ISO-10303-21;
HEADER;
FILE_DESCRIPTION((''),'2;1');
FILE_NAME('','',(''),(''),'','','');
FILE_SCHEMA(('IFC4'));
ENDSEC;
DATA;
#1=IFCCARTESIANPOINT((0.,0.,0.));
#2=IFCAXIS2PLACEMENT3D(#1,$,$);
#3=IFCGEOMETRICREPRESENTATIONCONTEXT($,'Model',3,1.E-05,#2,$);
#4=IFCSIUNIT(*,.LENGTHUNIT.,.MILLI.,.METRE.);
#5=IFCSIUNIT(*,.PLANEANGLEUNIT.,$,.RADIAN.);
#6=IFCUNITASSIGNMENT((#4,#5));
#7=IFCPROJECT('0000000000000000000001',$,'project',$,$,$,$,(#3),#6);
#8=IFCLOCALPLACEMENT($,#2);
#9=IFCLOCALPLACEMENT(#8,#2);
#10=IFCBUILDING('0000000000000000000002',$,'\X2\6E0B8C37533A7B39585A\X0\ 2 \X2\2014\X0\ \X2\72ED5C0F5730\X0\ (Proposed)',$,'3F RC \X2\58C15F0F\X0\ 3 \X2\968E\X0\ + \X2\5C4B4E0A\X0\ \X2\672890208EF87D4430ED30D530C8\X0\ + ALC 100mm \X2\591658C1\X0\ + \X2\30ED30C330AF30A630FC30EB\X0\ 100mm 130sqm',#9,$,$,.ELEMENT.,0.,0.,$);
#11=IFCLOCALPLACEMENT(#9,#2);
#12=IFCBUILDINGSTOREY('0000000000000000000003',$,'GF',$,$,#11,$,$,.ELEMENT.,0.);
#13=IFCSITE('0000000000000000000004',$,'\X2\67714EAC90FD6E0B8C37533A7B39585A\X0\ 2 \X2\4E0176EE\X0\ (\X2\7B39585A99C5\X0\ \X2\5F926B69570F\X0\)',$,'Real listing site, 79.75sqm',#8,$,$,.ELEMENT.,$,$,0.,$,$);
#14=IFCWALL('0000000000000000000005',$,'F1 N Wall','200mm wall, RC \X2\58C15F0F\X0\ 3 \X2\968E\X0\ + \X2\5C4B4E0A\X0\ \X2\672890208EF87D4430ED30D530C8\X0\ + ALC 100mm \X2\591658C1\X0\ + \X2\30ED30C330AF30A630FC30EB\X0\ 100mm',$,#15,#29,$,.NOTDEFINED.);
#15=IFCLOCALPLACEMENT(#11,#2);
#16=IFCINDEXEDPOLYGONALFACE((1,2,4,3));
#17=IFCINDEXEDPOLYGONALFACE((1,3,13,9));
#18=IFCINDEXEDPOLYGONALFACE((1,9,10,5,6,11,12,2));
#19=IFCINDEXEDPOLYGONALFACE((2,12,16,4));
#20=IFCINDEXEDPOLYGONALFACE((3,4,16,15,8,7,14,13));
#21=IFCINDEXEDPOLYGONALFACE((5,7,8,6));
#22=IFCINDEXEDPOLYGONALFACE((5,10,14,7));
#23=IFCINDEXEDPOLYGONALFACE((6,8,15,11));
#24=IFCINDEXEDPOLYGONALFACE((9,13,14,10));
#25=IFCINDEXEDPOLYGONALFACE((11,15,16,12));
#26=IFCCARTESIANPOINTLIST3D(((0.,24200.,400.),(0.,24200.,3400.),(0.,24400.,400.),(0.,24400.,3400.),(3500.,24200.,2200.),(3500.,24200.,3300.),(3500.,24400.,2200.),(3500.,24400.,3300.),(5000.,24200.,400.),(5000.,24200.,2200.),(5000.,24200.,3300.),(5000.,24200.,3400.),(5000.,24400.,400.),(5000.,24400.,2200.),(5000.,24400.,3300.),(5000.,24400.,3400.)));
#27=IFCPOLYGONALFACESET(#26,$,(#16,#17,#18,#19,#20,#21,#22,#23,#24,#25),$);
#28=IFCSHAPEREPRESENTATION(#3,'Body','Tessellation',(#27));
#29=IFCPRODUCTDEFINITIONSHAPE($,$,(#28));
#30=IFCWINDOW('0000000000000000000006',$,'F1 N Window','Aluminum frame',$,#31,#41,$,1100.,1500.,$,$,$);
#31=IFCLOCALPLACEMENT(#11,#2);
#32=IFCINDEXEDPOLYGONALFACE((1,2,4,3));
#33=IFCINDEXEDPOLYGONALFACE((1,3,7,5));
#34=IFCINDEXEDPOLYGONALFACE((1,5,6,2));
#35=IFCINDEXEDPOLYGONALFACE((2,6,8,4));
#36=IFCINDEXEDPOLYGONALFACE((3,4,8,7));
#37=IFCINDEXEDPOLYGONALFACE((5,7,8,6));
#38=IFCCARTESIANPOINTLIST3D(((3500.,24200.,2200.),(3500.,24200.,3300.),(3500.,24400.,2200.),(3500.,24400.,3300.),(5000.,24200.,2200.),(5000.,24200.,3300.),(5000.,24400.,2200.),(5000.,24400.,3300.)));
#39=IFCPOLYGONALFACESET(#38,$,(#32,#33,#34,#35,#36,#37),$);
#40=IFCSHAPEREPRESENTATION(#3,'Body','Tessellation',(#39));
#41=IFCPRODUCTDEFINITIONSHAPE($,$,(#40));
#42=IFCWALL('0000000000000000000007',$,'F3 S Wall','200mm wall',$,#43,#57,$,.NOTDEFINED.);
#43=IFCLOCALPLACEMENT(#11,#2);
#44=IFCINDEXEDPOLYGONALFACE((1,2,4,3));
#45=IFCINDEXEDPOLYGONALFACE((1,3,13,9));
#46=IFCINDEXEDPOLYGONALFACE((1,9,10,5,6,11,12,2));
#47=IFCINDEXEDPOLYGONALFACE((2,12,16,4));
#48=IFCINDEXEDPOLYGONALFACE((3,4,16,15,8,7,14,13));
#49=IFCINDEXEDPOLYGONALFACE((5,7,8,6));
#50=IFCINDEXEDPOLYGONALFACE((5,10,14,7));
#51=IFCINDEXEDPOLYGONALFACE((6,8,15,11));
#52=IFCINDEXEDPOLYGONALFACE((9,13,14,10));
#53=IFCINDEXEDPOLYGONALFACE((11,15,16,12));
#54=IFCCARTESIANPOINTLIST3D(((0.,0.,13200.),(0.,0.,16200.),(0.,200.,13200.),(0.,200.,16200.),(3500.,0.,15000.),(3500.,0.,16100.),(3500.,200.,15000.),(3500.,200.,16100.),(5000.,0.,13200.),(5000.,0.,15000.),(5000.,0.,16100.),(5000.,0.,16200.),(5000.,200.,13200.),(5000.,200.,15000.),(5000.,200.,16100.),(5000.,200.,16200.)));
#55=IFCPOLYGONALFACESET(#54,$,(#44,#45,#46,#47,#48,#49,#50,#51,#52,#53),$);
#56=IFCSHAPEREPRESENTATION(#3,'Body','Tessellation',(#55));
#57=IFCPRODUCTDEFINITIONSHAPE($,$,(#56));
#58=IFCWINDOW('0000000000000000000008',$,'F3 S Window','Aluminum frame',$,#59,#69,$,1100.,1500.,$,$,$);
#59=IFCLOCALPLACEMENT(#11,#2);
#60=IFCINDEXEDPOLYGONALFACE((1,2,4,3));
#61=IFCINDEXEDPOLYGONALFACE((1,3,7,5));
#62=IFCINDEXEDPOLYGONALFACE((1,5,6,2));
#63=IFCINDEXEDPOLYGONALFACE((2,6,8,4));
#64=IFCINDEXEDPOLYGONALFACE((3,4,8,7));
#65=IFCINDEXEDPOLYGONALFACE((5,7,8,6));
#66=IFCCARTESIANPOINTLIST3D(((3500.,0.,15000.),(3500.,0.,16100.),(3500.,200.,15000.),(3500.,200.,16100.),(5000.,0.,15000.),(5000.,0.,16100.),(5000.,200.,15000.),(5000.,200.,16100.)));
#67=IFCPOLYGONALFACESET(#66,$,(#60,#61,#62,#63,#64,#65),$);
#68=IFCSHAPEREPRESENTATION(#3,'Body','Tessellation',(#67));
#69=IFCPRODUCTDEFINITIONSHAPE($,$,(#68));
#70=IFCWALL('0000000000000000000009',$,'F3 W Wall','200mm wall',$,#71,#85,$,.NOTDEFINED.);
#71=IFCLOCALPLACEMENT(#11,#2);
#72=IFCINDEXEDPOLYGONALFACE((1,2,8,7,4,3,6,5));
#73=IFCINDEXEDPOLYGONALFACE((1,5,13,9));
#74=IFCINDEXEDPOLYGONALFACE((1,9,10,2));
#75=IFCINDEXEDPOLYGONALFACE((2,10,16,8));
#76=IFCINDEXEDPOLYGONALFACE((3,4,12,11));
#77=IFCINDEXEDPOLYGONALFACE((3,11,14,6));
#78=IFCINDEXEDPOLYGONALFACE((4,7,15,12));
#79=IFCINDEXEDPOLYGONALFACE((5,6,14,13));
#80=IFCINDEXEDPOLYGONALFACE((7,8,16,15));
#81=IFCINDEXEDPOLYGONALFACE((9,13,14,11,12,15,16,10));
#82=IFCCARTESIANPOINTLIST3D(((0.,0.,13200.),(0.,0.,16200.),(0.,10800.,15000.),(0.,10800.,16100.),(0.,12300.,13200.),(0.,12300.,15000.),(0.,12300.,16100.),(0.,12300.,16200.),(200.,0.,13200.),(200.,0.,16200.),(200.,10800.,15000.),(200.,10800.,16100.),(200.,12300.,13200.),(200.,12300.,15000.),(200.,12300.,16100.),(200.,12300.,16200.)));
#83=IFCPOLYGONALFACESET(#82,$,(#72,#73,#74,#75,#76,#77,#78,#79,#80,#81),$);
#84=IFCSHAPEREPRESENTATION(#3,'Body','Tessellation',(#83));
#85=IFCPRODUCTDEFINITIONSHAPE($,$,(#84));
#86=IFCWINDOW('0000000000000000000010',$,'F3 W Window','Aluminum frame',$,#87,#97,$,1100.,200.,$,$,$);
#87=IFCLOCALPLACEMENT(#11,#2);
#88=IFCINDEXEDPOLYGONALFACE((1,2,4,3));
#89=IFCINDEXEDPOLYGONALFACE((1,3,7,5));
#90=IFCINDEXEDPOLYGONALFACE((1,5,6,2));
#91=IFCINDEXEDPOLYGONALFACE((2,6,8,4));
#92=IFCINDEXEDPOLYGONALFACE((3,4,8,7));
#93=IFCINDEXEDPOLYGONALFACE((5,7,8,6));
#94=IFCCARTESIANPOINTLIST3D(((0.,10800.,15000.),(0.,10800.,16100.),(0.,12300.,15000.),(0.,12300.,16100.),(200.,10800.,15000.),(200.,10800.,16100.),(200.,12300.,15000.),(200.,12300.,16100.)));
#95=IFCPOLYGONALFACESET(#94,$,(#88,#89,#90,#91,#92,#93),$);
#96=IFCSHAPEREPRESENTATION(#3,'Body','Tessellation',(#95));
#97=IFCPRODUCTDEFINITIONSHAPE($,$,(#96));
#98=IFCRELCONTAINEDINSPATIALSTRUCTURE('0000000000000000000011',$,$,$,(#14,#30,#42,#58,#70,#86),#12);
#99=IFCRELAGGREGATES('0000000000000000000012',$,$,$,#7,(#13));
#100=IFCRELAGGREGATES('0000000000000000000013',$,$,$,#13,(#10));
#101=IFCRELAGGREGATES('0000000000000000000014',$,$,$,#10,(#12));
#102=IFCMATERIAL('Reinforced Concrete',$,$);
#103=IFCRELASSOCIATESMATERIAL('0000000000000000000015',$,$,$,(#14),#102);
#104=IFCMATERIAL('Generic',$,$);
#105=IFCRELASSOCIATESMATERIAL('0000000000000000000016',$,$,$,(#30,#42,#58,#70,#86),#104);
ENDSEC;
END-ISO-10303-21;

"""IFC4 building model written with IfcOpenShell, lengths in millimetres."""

from ifc_helpers import new_model, si_unit, frame, frame_2d, origin, place, context, project, spatial, rectangle, extrude, material, element, fill, save


model = new_model("IFC4")

# Units and contexts
model_context = context("Model", 3, precision=1e-05, world=origin())
ifc_project = project(units=[si_unit("LENGTHUNIT", "METRE", prefix="MILLI"), si_unit("PLANEANGLEUNIT", "RADIAN")], contexts=[model_context])

# Site, building, storey
site_placement = place(None, origin())
site = spatial("IfcSite", under=ifc_project, at=site_placement, Name="東京都渋谷区笹塚 2 丁目 (笹塚駅 徒歩圏)", ObjectType="Real listing site, 79.75sqm", CompositionType="ELEMENT", RefElevation=0.0)
building_placement = place(site_placement, origin())
building = spatial("IfcBuilding", under=site, at=building_placement, Name="渋谷区笹塚 2 — 狭小地 (Proposed)", ObjectType="3F RC 壁式 3 階 + 屋上 木造軸組ロフト + ALC 100mm 外壁 + ロックウール 100mm 130sqm", CompositionType="ELEMENT", ElevationOfRefHeight=0.0, ElevationOfTerrain=0.0)
storey_placement = place(building_placement, origin())
storey = spatial("IfcBuildingStorey", under=building, at=storey_placement, Name="GF", CompositionType="ELEMENT", Elevation=0.0)

# Shared definitions
ifc_material_1 = material(Name="Reinforced Concrete")

# Walls, openings, windows
wall_1_placement = place(storey_placement, frame((0.0, 12100.0, 200.0)))
wall_1 = element("IfcWall", 1, at=wall_1_placement, inside=storey, material=ifc_material_1, Name="F1 N Wall", Description="200mm wall, RC 壁式 3 階 + 屋上 木造軸組ロフト + ALC 100mm 外壁 + ロックウール 100mm", PredefinedType="NOTDEFINED", context=model_context, shape_type="SweptSolid", body=[
    extrude(rectangle(XDim=5000.0, YDim=200.0, at=frame_2d((2500.0, 100.0))), frame((0.0, 12100.0, 200.0)), (0.0, 0.0, 1.0), 3000.0),
])
opening_1_placement = place(storey_placement, frame((1750.0, 12100.0, 1100.0)))
opening_1 = element("IfcOpeningElement", 2, at=opening_1_placement, cuts=wall_1, PredefinedType="NOTDEFINED", context=model_context, shape_type="SweptSolid", body=[
    extrude(rectangle(XDim=1500.0, YDim=200.0, at=frame_2d((750.0, 100.0))), frame((1750.0, 12100.0, 1100.0)), (0.0, 0.0, 1.0), 1100.0),
])
ifc_material_2 = material(Name="Generic")
window_1_placement = place(storey_placement, frame((1750.0, 12100.0, 1100.0)))
window_1 = element("IfcWindow", 3, at=window_1_placement, inside=storey, material=ifc_material_2, Name="F1 N Window", Description="Aluminum frame", OverallHeight=1100.0, OverallWidth=1500.0, context=model_context, shape_type="SweptSolid", body=[
    extrude(rectangle(XDim=1500.0, YDim=200.0, at=frame_2d((750.0, 100.0))), frame((1750.0, 12100.0, 1100.0)), (0.0, 0.0, 1.0), 1100.0),
])
fill(opening_1, window_1)
wall_2_placement = place(storey_placement, frame((0.0, 0.0, 6600.0)))
wall_2 = element("IfcWall", 4, at=wall_2_placement, inside=storey, material=ifc_material_2, Name="F3 S Wall", Description="200mm wall", PredefinedType="NOTDEFINED", context=model_context, shape_type="SweptSolid", body=[
    extrude(rectangle(XDim=5000.0, YDim=200.0, at=frame_2d((2500.0, 100.0))), frame((0.0, 0.0, 6600.0)), (0.0, 0.0, 1.0), 3000.0),
])
opening_2_placement = place(storey_placement, frame((1750.0, 0.0, 7500.0)))
opening_2 = element("IfcOpeningElement", 5, at=opening_2_placement, cuts=wall_2, PredefinedType="NOTDEFINED", context=model_context, shape_type="SweptSolid", body=[
    extrude(rectangle(XDim=1500.0, YDim=200.0, at=frame_2d((750.0, 100.0))), frame((1750.0, 0.0, 7500.0)), (0.0, 0.0, 1.0), 1100.0),
])
window_2_placement = place(storey_placement, frame((1750.0, 0.0, 7500.0)))
window_2 = element("IfcWindow", 6, at=window_2_placement, inside=storey, material=ifc_material_2, Name="F3 S Window", Description="Aluminum frame", OverallHeight=1100.0, OverallWidth=1500.0, context=model_context, shape_type="SweptSolid", body=[
    extrude(rectangle(XDim=1500.0, YDim=200.0, at=frame_2d((750.0, 100.0))), frame((1750.0, 0.0, 7500.0)), (0.0, 0.0, 1.0), 1100.0),
])
fill(opening_2, window_2)
wall_3_placement = place(storey_placement, frame((0.0, 0.0, 6600.0)))
wall_3 = element("IfcWall", 7, at=wall_3_placement, inside=storey, material=ifc_material_2, Name="F3 W Wall", Description="200mm wall", PredefinedType="NOTDEFINED", context=model_context, shape_type="SweptSolid", body=[
    extrude(rectangle(XDim=200.0, YDim=12300.0, at=frame_2d((100.0, 6150.0))), frame((0.0, 0.0, 6600.0)), (0.0, 0.0, 1.0), 3000.0),
])
opening_3_placement = place(storey_placement, frame((0.0, 5400.0, 7500.0)))
opening_3 = element("IfcOpeningElement", 8, at=opening_3_placement, cuts=wall_3, PredefinedType="NOTDEFINED", context=model_context, shape_type="SweptSolid", body=[
    extrude(rectangle(XDim=200.0, YDim=1500.0, at=frame_2d((100.0, 750.0))), frame((0.0, 5400.0, 7500.0)), (0.0, 0.0, 1.0), 1100.0),
])
window_3_placement = place(storey_placement, frame((0.0, 5400.0, 7500.0)))
window_3 = element("IfcWindow", 9, at=window_3_placement, inside=storey, material=ifc_material_2, Name="F3 W Window", Description="Aluminum frame", OverallHeight=1100.0, OverallWidth=200.0, context=model_context, shape_type="SweptSolid", body=[
    extrude(rectangle(XDim=200.0, YDim=1500.0, at=frame_2d((100.0, 750.0))), frame((0.0, 5400.0, 7500.0)), (0.0, 0.0, 1.0), 1100.0),
])
fill(opening_3, window_3)

save(model, "model.ifc")
